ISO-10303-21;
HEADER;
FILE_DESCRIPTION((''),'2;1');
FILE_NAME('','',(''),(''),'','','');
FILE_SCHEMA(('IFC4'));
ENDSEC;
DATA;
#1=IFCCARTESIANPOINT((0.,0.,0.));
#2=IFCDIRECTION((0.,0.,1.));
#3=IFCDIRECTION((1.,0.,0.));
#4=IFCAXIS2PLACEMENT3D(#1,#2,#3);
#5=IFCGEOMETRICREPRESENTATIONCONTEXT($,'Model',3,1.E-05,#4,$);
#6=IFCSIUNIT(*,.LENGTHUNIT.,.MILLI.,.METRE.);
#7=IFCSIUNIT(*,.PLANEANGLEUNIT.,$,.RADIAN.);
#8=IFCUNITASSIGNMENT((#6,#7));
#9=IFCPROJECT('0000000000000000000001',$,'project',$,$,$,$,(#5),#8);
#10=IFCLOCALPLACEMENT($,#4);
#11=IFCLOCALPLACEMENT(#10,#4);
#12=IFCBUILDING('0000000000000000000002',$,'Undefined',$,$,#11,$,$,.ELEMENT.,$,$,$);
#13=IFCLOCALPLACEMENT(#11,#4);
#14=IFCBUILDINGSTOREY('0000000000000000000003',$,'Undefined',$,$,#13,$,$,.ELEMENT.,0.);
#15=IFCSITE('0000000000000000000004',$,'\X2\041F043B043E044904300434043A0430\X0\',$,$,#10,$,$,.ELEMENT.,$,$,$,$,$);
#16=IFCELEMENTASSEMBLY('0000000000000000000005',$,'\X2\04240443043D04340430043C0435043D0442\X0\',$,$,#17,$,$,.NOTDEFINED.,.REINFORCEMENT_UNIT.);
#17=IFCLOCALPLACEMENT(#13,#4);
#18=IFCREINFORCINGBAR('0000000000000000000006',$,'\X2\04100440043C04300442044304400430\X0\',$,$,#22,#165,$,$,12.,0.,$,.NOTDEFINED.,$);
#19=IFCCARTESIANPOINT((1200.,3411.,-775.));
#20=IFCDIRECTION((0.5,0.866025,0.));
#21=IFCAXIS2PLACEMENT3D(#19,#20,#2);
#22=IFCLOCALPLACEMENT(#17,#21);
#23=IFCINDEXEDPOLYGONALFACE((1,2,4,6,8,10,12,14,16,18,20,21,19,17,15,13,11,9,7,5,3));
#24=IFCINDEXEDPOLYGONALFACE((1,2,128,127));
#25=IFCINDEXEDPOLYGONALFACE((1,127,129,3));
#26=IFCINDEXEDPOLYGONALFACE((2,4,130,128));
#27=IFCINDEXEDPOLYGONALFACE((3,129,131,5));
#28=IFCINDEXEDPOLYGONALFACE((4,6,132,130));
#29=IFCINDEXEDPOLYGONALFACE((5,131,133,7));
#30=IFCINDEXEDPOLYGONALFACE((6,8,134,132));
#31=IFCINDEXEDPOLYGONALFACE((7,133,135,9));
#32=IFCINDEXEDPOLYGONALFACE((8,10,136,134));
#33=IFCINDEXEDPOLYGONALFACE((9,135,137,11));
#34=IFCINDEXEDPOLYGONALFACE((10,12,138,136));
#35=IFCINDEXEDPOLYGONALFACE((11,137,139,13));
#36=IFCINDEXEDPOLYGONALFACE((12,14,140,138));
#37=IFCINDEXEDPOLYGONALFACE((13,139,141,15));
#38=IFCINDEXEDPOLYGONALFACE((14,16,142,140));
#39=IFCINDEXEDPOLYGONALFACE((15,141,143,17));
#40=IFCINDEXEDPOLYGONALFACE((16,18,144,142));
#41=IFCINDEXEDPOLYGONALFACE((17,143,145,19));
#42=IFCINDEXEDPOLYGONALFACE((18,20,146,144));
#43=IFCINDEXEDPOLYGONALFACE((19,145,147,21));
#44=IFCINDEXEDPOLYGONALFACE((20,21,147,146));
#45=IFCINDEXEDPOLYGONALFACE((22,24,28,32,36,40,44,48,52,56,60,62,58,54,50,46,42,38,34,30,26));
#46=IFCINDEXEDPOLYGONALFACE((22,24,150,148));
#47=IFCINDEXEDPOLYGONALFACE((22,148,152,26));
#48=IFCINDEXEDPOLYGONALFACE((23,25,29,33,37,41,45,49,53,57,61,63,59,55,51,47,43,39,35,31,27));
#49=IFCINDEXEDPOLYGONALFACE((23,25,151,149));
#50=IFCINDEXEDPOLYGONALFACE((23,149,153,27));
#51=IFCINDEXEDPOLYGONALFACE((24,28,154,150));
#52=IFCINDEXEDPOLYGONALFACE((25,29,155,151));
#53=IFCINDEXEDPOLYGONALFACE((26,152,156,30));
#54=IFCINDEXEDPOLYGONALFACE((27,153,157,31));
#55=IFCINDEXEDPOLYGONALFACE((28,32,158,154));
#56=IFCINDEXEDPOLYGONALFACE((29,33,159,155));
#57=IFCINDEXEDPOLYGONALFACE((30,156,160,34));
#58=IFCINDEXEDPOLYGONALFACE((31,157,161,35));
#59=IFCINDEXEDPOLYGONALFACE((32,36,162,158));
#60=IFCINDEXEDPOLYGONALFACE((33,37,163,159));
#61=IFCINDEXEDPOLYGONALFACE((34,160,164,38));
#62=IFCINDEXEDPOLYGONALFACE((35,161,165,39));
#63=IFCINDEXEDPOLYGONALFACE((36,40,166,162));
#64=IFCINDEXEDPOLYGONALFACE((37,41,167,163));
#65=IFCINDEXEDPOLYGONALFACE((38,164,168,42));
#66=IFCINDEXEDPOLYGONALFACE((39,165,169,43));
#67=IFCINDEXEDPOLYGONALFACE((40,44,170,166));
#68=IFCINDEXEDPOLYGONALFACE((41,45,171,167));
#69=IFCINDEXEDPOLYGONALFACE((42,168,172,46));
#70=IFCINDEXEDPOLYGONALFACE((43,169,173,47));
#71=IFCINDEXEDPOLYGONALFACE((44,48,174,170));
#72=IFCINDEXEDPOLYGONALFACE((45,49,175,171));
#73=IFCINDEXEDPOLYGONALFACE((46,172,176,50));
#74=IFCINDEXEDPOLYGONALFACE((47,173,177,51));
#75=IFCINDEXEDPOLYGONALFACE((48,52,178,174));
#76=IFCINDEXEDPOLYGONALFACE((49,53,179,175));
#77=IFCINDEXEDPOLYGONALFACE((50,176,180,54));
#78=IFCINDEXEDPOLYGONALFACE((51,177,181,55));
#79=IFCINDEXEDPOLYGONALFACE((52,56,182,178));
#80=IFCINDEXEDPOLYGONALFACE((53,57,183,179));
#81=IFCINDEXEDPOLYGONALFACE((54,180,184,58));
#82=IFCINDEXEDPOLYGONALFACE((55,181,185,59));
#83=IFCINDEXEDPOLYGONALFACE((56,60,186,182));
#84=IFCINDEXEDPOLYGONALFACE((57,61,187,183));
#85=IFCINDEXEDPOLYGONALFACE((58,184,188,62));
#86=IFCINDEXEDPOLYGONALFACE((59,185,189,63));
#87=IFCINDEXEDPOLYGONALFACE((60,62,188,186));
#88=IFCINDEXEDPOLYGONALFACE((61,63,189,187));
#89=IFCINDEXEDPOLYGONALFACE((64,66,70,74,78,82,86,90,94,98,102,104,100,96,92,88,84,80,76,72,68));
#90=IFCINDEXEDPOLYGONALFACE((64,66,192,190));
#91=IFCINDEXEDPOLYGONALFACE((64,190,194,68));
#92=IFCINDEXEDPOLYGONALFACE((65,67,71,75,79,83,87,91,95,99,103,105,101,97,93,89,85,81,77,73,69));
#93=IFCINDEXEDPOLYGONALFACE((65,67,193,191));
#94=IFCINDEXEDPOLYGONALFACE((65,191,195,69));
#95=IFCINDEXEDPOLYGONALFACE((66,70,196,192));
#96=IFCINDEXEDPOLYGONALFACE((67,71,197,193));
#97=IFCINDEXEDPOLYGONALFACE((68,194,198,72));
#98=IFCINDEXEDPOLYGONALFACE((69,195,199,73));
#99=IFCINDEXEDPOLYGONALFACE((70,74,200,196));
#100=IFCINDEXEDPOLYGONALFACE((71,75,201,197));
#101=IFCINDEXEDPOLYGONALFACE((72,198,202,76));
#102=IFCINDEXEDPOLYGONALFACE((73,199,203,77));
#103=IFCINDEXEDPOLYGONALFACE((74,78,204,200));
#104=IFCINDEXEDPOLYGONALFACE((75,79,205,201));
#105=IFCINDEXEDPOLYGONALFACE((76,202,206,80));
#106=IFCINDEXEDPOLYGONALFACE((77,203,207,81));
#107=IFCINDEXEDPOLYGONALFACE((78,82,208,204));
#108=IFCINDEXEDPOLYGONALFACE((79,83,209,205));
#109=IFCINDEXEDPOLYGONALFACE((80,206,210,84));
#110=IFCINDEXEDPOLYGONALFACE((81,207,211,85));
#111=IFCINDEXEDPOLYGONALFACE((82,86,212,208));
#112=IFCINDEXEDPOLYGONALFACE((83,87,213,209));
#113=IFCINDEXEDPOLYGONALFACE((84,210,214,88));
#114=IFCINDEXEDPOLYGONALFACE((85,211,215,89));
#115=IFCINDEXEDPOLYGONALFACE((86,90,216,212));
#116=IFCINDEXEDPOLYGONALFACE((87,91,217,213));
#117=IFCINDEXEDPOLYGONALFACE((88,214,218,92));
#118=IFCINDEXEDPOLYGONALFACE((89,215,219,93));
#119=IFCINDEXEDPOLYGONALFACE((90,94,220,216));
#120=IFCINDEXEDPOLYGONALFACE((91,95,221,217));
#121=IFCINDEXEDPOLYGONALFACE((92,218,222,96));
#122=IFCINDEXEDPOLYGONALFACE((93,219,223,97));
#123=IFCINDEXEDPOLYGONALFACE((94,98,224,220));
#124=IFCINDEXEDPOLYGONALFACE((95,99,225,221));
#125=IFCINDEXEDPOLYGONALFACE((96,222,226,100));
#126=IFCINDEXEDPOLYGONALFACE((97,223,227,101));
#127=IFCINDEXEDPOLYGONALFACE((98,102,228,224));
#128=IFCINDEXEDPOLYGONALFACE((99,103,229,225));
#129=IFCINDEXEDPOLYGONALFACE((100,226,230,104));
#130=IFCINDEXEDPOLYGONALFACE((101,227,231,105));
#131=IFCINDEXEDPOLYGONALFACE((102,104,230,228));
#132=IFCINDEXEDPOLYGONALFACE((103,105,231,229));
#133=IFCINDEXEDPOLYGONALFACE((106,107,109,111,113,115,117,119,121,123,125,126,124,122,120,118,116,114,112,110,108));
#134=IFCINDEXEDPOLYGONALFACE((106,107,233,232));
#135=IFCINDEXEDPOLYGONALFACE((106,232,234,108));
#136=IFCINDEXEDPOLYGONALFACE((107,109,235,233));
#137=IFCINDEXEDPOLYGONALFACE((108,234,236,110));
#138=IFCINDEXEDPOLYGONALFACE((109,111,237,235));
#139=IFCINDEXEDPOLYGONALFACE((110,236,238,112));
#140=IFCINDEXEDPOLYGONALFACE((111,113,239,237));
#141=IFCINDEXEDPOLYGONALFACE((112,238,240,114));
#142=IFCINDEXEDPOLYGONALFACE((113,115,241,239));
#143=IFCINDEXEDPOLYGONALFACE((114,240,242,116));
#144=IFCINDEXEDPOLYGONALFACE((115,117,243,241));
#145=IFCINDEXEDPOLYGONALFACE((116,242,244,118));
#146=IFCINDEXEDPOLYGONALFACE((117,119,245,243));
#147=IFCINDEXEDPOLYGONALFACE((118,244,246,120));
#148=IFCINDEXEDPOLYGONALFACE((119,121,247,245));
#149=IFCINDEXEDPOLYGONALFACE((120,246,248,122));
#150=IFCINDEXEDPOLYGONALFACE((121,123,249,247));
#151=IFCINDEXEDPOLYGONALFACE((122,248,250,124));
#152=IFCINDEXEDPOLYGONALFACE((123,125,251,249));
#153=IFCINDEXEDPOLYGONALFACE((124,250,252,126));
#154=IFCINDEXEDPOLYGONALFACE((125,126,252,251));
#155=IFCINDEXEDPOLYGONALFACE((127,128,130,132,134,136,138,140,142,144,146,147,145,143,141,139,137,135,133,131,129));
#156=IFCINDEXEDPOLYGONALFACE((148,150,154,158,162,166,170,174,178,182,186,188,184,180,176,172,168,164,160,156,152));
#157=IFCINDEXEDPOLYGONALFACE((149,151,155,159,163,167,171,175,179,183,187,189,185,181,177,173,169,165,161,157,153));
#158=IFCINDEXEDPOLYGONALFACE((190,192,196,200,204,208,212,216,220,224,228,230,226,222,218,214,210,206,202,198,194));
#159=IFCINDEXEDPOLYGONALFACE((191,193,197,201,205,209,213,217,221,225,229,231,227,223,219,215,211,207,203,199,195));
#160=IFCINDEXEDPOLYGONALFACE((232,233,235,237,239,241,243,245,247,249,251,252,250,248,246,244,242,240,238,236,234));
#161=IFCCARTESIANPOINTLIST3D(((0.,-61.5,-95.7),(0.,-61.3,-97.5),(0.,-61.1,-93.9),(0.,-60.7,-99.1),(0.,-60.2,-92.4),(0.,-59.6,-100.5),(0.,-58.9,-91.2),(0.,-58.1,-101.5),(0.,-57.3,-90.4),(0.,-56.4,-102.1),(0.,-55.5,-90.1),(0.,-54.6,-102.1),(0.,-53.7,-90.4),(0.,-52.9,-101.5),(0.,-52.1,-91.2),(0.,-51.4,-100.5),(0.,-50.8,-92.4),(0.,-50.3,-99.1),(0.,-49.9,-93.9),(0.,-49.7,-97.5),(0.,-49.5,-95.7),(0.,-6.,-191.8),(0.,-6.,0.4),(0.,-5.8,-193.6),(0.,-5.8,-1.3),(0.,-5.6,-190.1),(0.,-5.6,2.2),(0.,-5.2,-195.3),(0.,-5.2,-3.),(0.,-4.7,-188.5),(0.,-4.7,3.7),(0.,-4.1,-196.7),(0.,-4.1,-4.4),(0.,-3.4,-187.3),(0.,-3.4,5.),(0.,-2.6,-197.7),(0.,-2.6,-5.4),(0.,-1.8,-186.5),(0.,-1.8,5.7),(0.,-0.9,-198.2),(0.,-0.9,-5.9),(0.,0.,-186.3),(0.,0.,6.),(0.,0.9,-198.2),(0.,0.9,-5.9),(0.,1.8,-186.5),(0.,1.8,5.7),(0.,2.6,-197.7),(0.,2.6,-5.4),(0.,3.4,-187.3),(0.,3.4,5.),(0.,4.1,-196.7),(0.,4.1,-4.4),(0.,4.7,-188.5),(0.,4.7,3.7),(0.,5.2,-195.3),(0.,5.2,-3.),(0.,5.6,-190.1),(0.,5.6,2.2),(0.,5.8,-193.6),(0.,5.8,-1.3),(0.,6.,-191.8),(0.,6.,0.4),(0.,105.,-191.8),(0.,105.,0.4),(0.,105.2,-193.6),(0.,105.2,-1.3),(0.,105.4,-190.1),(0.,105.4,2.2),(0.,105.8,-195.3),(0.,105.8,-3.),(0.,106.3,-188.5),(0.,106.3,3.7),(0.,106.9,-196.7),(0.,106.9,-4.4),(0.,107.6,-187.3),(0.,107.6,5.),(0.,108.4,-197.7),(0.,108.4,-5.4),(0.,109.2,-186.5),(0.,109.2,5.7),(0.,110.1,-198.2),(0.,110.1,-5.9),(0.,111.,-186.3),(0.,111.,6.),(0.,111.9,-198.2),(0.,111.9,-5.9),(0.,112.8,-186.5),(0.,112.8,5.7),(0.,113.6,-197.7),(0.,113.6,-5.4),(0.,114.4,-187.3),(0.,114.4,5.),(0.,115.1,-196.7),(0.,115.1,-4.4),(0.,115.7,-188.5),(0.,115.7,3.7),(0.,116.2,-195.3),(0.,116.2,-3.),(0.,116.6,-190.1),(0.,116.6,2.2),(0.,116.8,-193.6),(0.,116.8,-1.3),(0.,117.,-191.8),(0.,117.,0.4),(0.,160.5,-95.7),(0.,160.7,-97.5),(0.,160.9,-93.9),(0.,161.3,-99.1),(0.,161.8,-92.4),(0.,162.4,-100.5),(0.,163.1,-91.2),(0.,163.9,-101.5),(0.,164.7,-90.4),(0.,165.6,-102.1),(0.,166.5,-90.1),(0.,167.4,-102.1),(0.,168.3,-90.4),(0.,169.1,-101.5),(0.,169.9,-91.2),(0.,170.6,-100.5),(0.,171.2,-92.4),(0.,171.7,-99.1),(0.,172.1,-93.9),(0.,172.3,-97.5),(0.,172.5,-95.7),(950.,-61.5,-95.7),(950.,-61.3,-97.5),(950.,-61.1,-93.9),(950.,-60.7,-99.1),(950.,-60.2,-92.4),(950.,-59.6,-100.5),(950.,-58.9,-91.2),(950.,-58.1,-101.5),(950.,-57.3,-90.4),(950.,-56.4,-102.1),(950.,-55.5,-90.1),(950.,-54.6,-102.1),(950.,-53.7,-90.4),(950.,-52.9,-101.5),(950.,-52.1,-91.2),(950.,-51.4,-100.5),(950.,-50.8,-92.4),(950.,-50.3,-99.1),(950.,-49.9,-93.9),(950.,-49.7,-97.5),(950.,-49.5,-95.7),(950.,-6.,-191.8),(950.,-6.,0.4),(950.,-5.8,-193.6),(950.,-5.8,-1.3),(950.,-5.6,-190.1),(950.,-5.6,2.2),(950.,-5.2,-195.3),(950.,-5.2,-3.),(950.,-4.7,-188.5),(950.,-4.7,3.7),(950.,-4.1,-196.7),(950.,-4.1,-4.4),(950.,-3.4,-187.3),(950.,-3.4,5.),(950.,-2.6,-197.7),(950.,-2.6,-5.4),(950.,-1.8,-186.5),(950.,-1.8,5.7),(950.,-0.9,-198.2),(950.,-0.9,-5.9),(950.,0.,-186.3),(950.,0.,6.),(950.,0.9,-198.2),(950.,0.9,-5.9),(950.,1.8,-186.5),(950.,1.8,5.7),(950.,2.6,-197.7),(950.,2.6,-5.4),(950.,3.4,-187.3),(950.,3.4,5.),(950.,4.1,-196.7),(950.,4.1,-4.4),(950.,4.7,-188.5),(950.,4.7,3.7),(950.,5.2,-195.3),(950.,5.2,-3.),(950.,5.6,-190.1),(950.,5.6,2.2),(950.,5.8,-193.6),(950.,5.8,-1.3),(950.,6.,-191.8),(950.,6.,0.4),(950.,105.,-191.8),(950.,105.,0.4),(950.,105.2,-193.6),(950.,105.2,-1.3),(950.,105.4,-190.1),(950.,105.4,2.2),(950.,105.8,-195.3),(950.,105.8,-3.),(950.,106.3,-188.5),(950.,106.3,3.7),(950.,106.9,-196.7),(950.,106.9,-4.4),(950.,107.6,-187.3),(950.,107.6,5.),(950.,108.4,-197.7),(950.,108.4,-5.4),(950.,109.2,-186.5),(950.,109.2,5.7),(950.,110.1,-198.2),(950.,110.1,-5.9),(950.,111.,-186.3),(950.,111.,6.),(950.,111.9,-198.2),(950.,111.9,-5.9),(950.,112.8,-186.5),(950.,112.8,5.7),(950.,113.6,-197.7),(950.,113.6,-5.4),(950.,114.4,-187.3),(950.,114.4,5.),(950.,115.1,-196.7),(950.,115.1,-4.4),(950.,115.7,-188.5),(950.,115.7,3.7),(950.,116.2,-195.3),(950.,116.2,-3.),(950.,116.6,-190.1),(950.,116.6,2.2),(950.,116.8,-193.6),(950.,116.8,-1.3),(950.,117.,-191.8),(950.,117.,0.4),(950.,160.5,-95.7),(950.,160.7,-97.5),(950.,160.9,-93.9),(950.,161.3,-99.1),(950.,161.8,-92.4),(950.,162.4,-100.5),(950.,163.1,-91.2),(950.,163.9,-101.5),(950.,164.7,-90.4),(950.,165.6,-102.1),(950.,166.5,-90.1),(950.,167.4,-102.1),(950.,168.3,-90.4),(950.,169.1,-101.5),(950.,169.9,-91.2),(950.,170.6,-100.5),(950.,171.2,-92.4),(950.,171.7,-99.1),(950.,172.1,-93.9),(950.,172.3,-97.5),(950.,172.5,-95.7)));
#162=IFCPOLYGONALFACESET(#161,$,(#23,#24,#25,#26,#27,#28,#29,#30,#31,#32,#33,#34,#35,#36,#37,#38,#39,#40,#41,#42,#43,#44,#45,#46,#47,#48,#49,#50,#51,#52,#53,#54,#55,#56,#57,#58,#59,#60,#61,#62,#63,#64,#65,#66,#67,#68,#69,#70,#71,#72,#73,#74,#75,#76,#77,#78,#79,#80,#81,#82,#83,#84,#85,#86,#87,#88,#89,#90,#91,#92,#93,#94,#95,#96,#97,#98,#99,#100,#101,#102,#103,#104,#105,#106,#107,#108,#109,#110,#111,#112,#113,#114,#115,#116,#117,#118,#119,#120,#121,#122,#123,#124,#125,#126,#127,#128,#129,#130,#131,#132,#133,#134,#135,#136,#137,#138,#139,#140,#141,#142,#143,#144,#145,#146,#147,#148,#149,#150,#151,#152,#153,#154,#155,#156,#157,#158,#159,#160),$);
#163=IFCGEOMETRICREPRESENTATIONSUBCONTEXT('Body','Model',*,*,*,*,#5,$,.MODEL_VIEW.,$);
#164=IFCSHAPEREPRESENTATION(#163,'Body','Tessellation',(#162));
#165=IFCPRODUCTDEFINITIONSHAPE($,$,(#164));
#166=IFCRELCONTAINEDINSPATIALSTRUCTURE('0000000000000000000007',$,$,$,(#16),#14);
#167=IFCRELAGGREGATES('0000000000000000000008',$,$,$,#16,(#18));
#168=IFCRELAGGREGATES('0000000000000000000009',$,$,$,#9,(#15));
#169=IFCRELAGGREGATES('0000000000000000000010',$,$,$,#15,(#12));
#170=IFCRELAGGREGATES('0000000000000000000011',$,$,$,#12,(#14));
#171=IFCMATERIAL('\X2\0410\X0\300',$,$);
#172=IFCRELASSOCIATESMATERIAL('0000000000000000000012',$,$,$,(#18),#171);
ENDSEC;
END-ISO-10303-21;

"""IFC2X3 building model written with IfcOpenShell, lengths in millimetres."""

from ifc_helpers import new_model, entity, si_unit, frame, origin_with_axes, place, context, subcontext, project, spatial, source, transform, mapped, material, element, aggregate, save


model = new_model("IFC2X3")

# Units and contexts
model_context = context("Model", 3, precision=1e-05, world=origin_with_axes())
body_context = subcontext(model_context, "Body", "Model", "MODEL_VIEW")
ifc_project = project(units=[si_unit("LENGTHUNIT", "METRE", prefix="MILLI"), si_unit("PLANEANGLEUNIT", "RADIAN")], contexts=[model_context])

# Site, building, storey
site_placement = place(None, origin_with_axes())
site = spatial("IfcSite", under=ifc_project, at=site_placement, Name="Площадка", CompositionType="ELEMENT")
building_placement = place(site_placement, origin_with_axes())
building = spatial("IfcBuilding", under=site, at=building_placement, Name="Undefined", CompositionType="ELEMENT")
storey_placement = place(building_placement, origin_with_axes())
storey = spatial("IfcBuildingStorey", under=building, at=storey_placement, Name="Undefined", CompositionType="ELEMENT", Elevation=0.0)

# Element assembly, reinforcing bar
assembly_1_placement = place(storey_placement, origin_with_axes())
assembly_1 = element("IfcElementAssembly", 1, at=assembly_1_placement, inside=storey, Name="Фундамент", AssemblyPlace="NOTDEFINED", PredefinedType="REINFORCEMENT_UNIT")
ifc_material_1 = material(Name="А300")
shared_shape_1 = source(origin_with_axes(), body_context, "Body", "AdvancedSweptSolid", [
    entity("IfcSweptDiskSolid", entity("IfcTrimmedCurve", entity("IfcLine", entity("IfcCartesianPoint", [0.0, 0.0, 0.0]), entity("IfcVector", entity("IfcDirection", [1.0, 0.0, 0.0]), 1.0)), [entity("IfcParameterValue", 0.0)], [entity("IfcParameterValue", 950.0)], True, "PARAMETER"), 6.0, None, 0.0, 950.0),
])
shared_shape_2 = source(origin_with_axes(), body_context, "Body", "AdvancedSweptSolid", [
    entity("IfcSweptDiskSolid", entity("IfcTrimmedCurve", entity("IfcLine", entity("IfcCartesianPoint", [0.0, 0.0, 0.0]), entity("IfcVector", entity("IfcDirection", [1.0, 0.0, 0.0]), 1.0)), [entity("IfcParameterValue", 0.0)], [entity("IfcParameterValue", 950.0)], True, "PARAMETER"), 6.0, None, 0.0, 950.0),
])
shared_shape_3 = source(origin_with_axes(), body_context, "Body", "AdvancedSweptSolid", [
    entity("IfcSweptDiskSolid", entity("IfcTrimmedCurve", entity("IfcLine", entity("IfcCartesianPoint", [0.0, 0.0, 0.0]), entity("IfcVector", entity("IfcDirection", [1.0, 0.0, 0.0]), 1.0)), [entity("IfcParameterValue", 0.0)], [entity("IfcParameterValue", 950.0)], True, "PARAMETER"), 6.0, None, 0.0, 950.0),
])
shared_shape_4 = source(origin_with_axes(), body_context, "Body", "AdvancedSweptSolid", [
    entity("IfcSweptDiskSolid", entity("IfcTrimmedCurve", entity("IfcLine", entity("IfcCartesianPoint", [0.0, 0.0, 0.0]), entity("IfcVector", entity("IfcDirection", [1.0, 0.0, 0.0]), 1.0)), [entity("IfcParameterValue", 0.0)], [entity("IfcParameterValue", 950.0)], True, "PARAMETER"), 6.0, None, 0.0, 950.0),
])
shared_shape_5 = source(origin_with_axes(), body_context, "Body", "AdvancedSweptSolid", [
    entity("IfcSweptDiskSolid", entity("IfcTrimmedCurve", entity("IfcLine", entity("IfcCartesianPoint", [0.0, 0.0, 0.0]), entity("IfcVector", entity("IfcDirection", [1.0, 0.0, 0.0]), 1.0)), [entity("IfcParameterValue", 0.0)], [entity("IfcParameterValue", 950.0)], True, "PARAMETER"), 6.0, None, 0.0, 950.0),
])
shared_shape_6 = source(origin_with_axes(), body_context, "Body", "AdvancedSweptSolid", [
    entity("IfcSweptDiskSolid", entity("IfcTrimmedCurve", entity("IfcLine", entity("IfcCartesianPoint", [0.0, 0.0, 0.0]), entity("IfcVector", entity("IfcDirection", [1.0, 0.0, 0.0]), 1.0)), [entity("IfcParameterValue", 0.0)], [entity("IfcParameterValue", 950.0)], True, "PARAMETER"), 6.0, None, 0.0, 950.0),
])
reinforcing_bar_1_placement = place(assembly_1_placement, frame((1200.0, 3411.0, -775.0), z_axis=(0.5, 0.866025, 0.0), x_axis=(0.0, 0.0, 1.0)))
reinforcing_bar_1 = element("IfcReinforcingBar", 2, at=reinforcing_bar_1_placement, material=ifc_material_1, Name="Арматура", BarRole="NOTDEFINED", CrossSectionArea=0.0, NominalDiameter=12.0, context=body_context, shape_type="MappedRepresentation", body=[
    mapped(shared_shape_1, transform((0.0, 0.0, 0.0))),
    mapped(shared_shape_2, transform((0.0, -55.5, -96.1))),
    mapped(shared_shape_3, transform((0.0, 0.0, -192.3))),
    mapped(shared_shape_4, transform((0.0, 111.0, -192.3))),
    mapped(shared_shape_5, transform((0.0, 166.5, -96.1))),
    mapped(shared_shape_6, transform((0.0, 111.0, 0.0))),
])
aggregate(assembly_1, [reinforcing_bar_1])

save(model, "model.ifc")
